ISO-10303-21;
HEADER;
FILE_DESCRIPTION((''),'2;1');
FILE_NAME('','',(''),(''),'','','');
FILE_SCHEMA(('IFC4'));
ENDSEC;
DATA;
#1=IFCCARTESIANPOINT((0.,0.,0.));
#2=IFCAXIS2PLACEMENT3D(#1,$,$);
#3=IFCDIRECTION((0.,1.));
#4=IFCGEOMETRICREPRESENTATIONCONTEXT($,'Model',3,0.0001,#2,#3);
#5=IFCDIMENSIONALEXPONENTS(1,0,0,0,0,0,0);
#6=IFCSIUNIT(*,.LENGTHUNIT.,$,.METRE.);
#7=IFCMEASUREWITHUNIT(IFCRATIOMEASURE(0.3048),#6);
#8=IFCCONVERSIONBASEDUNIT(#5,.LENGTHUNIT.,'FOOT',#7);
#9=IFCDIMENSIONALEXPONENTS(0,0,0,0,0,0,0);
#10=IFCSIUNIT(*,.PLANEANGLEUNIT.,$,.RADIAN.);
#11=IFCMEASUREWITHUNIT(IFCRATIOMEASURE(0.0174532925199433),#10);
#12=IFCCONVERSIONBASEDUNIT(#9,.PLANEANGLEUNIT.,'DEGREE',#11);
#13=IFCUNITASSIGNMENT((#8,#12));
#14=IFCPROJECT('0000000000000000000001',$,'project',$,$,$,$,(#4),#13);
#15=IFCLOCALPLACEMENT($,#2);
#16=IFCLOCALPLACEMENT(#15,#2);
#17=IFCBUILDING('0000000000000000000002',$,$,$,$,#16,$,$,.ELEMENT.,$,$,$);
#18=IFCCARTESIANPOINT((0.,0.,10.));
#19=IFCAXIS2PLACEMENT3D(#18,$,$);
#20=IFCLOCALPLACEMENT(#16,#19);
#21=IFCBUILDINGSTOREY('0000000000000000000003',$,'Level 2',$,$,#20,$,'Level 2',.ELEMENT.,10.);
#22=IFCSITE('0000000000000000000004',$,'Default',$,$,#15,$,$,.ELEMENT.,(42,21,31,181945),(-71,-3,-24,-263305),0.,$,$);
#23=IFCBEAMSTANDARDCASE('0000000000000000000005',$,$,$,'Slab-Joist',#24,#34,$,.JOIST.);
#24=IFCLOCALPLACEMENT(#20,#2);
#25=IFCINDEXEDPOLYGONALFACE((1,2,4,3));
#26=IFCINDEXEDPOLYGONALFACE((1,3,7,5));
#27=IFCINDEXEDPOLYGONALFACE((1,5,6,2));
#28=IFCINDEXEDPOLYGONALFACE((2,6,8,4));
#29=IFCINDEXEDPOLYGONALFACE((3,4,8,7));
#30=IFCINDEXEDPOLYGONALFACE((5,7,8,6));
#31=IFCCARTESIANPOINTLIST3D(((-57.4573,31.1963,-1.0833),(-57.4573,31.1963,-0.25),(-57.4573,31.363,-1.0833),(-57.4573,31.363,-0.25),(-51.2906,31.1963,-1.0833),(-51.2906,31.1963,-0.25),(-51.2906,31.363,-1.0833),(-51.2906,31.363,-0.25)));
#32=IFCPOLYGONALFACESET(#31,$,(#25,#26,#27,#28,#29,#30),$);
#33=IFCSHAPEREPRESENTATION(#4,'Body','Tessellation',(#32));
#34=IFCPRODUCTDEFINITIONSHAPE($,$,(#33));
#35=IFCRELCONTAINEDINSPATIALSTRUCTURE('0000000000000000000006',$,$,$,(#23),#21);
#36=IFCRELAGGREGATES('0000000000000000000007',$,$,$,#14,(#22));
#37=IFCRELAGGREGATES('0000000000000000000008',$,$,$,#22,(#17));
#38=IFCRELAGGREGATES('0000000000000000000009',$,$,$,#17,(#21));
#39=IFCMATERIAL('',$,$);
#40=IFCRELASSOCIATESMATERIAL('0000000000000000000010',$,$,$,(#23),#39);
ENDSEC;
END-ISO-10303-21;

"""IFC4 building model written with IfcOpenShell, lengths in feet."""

from ifc_helpers import new_model, entity, si_unit, converted_unit, direction, frame, origin, origin_with_axes, place, context, project, spatial, rectangle, extrude, material, element, save


model = new_model("IFC4")

# Units and contexts
model_context = context("Model", 3, precision=0.0001, world=origin(), true_north=direction((0.0, 1.0)))
ifc_project = project(units=[converted_unit("LENGTHUNIT", "FOOT", entity("IfcRatioMeasure", 0.3048), si_unit("LENGTHUNIT", "METRE"), dimensions=[1, 0, 0, 0, 0, 0, 0]), converted_unit("PLANEANGLEUNIT", "DEGREE", entity("IfcRatioMeasure", 0.0174532925199433), si_unit("PLANEANGLEUNIT", "RADIAN"), dimensions=[0, 0, 0, 0, 0, 0, 0])], contexts=[model_context])

# Site, building, storey
site_placement = place(None, origin())
site = spatial("IfcSite", under=ifc_project, at=site_placement, Name="Default", CompositionType="ELEMENT", RefLatitude=(42, 21, 31, 181945), RefLongitude=(-71, -3, -24, -263305), RefElevation=0.0)
building_placement = place(site_placement, origin())
building = spatial("IfcBuilding", under=site, at=building_placement, CompositionType="ELEMENT")
storey_placement = place(building_placement, frame((0.0, 0.0, 10.0)))
storey = spatial("IfcBuildingStorey", under=building, at=storey_placement, Name="Level 2", LongName="Level 2", CompositionType="ELEMENT", Elevation=10.0)

# Beam
ifc_material_1 = material(Name="")
placement_1 = place(storey_placement, frame((-57.4573, 31.2797, 0.0), z_axis=(0.0, 0.0, 1.0), x_axis=(1.0, 0.0, 0.0)))
beam_1_placement = place(placement_1, frame((0.0, 0.0, -0.6667), z_axis=(1.0, 0.0, 0.0), x_axis=(0.0, 1.0, 0.0)))
element("IfcBeamStandardCase", 1, at=beam_1_placement, inside=storey, material=ifc_material_1, ObjectType="Slab-Joist", PredefinedType="JOIST", context=model_context, shape_type="SweptSolid", body=[
    extrude(rectangle(XDim=0.1667, YDim=0.8333), origin_with_axes(), (0.0, 0.0, 1.0), 6.1667),
])

save(model, "model.ifc")
